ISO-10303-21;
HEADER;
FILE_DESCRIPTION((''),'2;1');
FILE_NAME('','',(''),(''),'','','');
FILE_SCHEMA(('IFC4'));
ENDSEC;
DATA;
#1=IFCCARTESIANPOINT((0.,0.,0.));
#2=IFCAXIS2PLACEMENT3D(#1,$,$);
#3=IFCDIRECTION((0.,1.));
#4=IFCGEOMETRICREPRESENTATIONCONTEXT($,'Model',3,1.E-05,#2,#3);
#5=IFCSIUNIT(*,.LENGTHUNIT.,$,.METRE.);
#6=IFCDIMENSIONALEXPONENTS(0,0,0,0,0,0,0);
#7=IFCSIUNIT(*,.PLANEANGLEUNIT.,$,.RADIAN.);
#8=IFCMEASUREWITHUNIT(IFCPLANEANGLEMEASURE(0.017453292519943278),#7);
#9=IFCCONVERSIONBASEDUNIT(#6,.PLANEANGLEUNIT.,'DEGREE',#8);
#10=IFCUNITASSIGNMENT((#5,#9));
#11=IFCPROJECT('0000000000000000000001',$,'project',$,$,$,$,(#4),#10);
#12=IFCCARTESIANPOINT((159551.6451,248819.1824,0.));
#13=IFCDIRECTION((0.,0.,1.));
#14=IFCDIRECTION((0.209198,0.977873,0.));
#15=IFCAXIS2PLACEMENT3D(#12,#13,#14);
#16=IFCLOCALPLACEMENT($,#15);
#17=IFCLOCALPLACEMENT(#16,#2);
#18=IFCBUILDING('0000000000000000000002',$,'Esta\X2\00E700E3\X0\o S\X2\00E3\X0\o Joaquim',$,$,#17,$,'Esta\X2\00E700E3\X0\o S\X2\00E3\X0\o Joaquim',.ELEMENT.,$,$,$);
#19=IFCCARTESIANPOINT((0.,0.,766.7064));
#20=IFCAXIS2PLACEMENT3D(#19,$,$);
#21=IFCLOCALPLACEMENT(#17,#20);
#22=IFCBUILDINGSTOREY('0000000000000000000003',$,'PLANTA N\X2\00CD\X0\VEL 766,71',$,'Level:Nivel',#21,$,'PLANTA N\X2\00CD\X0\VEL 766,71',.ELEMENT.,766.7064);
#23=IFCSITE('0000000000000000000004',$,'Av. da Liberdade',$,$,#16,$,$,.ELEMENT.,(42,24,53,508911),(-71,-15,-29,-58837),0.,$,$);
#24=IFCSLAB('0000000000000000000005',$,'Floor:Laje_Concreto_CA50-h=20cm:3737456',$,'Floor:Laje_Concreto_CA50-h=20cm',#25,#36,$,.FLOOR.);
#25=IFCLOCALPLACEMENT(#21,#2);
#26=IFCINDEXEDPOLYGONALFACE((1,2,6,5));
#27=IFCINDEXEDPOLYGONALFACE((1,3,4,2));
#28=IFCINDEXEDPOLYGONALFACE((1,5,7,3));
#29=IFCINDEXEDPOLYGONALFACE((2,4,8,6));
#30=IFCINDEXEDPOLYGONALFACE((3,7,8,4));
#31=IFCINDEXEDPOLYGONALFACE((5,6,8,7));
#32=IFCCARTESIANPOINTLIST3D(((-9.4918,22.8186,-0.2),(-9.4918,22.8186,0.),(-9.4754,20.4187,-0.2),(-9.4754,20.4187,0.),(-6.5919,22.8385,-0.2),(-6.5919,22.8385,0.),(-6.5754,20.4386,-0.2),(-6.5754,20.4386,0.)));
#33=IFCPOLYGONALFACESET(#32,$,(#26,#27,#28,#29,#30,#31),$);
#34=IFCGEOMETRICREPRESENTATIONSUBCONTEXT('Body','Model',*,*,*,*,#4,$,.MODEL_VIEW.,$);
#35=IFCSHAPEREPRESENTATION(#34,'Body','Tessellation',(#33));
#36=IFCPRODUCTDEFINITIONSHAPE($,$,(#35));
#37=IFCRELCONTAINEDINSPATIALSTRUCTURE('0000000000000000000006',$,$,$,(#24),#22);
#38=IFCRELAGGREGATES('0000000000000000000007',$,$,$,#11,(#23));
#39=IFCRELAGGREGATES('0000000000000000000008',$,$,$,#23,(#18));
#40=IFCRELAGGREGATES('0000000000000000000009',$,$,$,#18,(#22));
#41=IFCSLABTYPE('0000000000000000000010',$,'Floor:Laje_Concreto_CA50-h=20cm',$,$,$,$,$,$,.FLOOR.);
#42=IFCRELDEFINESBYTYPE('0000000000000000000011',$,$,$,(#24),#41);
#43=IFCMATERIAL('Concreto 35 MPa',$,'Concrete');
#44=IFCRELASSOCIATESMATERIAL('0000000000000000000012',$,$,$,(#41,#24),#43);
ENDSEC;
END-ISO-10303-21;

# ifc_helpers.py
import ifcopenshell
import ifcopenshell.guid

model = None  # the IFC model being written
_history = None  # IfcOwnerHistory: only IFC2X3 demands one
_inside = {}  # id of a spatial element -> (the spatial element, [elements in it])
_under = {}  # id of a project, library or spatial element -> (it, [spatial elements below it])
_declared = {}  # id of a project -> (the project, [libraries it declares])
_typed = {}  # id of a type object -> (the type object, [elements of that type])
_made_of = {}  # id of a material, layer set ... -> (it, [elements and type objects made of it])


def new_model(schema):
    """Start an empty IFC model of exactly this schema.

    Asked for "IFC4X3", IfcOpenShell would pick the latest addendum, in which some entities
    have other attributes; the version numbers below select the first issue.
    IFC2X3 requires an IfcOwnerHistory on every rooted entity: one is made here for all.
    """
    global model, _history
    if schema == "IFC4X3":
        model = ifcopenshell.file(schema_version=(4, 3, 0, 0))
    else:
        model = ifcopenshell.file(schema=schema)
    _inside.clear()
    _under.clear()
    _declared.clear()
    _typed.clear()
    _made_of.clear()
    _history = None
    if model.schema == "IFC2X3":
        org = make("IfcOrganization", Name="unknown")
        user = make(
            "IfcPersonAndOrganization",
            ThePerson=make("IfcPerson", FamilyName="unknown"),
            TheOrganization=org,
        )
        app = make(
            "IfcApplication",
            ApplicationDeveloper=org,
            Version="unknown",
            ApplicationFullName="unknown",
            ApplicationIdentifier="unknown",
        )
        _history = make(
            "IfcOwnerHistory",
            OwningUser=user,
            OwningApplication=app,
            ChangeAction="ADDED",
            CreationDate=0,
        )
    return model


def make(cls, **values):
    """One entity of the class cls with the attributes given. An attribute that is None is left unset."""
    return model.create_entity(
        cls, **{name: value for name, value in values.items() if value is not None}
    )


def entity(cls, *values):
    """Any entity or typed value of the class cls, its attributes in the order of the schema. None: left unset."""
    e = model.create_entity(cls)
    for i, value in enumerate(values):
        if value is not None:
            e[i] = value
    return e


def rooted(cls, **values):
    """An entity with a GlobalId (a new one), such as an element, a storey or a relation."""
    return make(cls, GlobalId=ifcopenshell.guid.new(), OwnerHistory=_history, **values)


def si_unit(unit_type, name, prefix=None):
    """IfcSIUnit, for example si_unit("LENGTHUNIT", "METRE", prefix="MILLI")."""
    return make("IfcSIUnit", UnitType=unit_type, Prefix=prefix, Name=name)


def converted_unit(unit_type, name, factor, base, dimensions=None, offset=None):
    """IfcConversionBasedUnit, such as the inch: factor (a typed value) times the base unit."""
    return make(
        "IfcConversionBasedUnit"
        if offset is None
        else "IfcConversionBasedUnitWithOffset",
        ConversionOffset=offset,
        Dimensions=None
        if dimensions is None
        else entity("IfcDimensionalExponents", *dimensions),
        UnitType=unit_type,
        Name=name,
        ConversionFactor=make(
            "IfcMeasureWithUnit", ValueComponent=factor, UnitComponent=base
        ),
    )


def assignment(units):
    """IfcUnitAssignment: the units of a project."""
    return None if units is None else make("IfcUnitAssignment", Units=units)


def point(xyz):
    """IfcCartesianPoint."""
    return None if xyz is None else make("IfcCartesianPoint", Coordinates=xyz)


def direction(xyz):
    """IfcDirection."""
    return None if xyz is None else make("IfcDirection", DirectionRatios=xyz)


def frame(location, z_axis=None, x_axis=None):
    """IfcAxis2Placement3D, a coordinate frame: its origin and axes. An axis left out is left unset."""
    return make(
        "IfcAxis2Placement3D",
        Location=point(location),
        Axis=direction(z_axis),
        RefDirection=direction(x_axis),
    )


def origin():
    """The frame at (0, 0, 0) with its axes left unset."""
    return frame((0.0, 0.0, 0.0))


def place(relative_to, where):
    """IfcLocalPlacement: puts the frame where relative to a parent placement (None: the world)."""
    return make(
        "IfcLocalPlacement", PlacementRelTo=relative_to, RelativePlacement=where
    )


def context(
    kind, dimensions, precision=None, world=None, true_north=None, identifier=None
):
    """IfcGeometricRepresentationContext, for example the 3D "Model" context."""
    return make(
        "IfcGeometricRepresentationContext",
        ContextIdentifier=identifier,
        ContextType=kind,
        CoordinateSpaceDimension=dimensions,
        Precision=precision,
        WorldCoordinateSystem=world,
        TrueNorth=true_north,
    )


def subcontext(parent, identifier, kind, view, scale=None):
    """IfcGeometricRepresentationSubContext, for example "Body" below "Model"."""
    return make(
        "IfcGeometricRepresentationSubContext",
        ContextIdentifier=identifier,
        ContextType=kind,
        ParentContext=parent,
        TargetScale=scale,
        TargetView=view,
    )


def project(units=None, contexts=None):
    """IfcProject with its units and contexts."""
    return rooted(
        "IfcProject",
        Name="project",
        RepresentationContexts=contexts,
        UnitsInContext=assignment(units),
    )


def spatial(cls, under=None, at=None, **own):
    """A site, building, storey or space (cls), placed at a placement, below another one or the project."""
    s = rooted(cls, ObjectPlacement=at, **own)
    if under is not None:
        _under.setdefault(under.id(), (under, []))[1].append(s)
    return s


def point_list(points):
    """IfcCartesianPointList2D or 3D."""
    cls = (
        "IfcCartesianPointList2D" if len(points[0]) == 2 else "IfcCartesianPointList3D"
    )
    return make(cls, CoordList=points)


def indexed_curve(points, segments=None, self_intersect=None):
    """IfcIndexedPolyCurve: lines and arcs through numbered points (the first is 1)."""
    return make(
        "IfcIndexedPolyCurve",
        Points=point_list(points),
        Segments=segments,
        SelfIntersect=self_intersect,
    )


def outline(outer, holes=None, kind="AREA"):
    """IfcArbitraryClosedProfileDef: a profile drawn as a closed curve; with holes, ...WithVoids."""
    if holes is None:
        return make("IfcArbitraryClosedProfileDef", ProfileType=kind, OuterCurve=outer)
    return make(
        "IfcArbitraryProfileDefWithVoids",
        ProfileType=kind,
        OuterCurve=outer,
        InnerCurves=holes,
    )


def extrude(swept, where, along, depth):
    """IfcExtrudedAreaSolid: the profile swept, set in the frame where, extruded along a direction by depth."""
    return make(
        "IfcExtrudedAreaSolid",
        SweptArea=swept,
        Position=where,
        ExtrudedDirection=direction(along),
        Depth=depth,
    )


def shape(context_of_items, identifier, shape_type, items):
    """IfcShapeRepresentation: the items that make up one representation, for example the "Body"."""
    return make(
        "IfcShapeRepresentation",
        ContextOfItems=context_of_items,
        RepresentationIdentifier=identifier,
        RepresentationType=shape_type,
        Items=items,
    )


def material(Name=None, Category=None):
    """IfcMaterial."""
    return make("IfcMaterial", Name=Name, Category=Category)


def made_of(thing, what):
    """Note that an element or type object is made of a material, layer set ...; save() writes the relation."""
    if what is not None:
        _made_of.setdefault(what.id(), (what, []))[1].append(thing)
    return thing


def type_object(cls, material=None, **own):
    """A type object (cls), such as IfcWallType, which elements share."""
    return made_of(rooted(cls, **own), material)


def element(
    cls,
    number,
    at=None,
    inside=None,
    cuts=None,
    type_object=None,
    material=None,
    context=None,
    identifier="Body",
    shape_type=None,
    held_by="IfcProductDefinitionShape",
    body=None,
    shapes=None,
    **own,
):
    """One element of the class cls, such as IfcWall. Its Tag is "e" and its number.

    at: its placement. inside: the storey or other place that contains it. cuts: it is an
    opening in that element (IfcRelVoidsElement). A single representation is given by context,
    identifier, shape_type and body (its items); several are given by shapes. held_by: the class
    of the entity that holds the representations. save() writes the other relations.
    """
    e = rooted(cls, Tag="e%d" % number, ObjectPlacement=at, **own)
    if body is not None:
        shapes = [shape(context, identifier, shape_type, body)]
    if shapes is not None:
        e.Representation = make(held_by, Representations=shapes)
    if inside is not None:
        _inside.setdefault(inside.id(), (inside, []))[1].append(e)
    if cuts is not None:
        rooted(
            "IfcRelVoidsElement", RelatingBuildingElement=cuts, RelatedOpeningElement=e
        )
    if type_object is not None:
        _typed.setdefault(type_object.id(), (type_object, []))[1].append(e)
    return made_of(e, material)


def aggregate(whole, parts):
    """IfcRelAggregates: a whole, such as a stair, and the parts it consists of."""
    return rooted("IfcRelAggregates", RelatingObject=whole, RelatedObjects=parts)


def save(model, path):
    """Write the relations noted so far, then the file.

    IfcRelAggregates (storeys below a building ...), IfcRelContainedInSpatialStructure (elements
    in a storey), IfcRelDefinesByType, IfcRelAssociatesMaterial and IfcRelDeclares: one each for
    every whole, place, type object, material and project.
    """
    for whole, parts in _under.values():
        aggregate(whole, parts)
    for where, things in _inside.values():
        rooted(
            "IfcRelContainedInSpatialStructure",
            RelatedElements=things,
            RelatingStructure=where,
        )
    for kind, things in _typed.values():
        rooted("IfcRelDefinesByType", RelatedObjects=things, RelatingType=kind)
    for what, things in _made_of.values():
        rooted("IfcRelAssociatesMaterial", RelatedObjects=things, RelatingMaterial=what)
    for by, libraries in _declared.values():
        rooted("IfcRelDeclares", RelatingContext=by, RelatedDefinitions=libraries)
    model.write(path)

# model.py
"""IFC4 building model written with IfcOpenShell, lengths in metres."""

from ifc_helpers import new_model, entity, si_unit, converted_unit, direction, frame, origin, place, context, subcontext, project, spatial, indexed_curve, outline, extrude, material, type_object, element, save


model = new_model("IFC4")

# Units and contexts
model_context = context("Model", 3, precision=1e-05, world=origin(), true_north=direction((0.0, 1.0)))
body_context = subcontext(model_context, "Body", "Model", "MODEL_VIEW")
ifc_project = project(units=[si_unit("LENGTHUNIT", "METRE"), converted_unit("PLANEANGLEUNIT", "DEGREE", entity("IfcPlaneAngleMeasure", 0.017453292519943278), si_unit("PLANEANGLEUNIT", "RADIAN"), dimensions=[0, 0, 0, 0, 0, 0, 0])], contexts=[model_context])

# Site, building, storey
site_placement = place(None, frame((159551.6451, 248819.1824, 0.0), z_axis=(0.0, 0.0, 1.0), x_axis=(0.209198, 0.977873, 0.0)))
site = spatial("IfcSite", under=ifc_project, at=site_placement, Name="Av. da Liberdade", CompositionType="ELEMENT", RefLatitude=(42, 24, 53, 508911), RefLongitude=(-71, -15, -29, -58837), RefElevation=0.0)
building_placement = place(site_placement, origin())
building = spatial("IfcBuilding", under=site, at=building_placement, Name="Estação São Joaquim", LongName="Estação São Joaquim", CompositionType="ELEMENT")
storey_placement = place(building_placement, frame((0.0, 0.0, 766.7064)))
storey = spatial("IfcBuildingStorey", under=building, at=storey_placement, Name="PLANTA NÍVEL 766,71", ObjectType="Level:Nivel", LongName="PLANTA NÍVEL 766,71", CompositionType="ELEMENT", Elevation=766.7064)

# Slab
ifc_material = material(Name="Concreto 35 MPa", Category="Concrete")
slab_type = type_object("IfcSlabType", Name="Floor:Laje_Concreto_CA50-h=20cm", PredefinedType="FLOOR", material=ifc_material)
slab_placement = place(storey_placement, origin())
element("IfcSlab", 1, at=slab_placement, inside=storey, type_object=slab_type, material=ifc_material, Name="Floor:Laje_Concreto_CA50-h=20cm:3737456", ObjectType="Floor:Laje_Concreto_CA50-h=20cm", PredefinedType="FLOOR", context=body_context, shape_type="SweptSolid", body=[
    extrude(outline(indexed_curve([(-1.2, -1.45), (1.2, -1.45), (1.2, 1.45), (-1.2, 1.45), (-1.2, -1.45)], self_intersect=False)), frame((-8.0336, 21.6286, 0.0), z_axis=(0.0, 0.0, -1.0), x_axis=(0.006868, -0.999976, 0.0)), (0.0, 0.0, 1.0), 0.2),
])

save(model, "model.ifc")
